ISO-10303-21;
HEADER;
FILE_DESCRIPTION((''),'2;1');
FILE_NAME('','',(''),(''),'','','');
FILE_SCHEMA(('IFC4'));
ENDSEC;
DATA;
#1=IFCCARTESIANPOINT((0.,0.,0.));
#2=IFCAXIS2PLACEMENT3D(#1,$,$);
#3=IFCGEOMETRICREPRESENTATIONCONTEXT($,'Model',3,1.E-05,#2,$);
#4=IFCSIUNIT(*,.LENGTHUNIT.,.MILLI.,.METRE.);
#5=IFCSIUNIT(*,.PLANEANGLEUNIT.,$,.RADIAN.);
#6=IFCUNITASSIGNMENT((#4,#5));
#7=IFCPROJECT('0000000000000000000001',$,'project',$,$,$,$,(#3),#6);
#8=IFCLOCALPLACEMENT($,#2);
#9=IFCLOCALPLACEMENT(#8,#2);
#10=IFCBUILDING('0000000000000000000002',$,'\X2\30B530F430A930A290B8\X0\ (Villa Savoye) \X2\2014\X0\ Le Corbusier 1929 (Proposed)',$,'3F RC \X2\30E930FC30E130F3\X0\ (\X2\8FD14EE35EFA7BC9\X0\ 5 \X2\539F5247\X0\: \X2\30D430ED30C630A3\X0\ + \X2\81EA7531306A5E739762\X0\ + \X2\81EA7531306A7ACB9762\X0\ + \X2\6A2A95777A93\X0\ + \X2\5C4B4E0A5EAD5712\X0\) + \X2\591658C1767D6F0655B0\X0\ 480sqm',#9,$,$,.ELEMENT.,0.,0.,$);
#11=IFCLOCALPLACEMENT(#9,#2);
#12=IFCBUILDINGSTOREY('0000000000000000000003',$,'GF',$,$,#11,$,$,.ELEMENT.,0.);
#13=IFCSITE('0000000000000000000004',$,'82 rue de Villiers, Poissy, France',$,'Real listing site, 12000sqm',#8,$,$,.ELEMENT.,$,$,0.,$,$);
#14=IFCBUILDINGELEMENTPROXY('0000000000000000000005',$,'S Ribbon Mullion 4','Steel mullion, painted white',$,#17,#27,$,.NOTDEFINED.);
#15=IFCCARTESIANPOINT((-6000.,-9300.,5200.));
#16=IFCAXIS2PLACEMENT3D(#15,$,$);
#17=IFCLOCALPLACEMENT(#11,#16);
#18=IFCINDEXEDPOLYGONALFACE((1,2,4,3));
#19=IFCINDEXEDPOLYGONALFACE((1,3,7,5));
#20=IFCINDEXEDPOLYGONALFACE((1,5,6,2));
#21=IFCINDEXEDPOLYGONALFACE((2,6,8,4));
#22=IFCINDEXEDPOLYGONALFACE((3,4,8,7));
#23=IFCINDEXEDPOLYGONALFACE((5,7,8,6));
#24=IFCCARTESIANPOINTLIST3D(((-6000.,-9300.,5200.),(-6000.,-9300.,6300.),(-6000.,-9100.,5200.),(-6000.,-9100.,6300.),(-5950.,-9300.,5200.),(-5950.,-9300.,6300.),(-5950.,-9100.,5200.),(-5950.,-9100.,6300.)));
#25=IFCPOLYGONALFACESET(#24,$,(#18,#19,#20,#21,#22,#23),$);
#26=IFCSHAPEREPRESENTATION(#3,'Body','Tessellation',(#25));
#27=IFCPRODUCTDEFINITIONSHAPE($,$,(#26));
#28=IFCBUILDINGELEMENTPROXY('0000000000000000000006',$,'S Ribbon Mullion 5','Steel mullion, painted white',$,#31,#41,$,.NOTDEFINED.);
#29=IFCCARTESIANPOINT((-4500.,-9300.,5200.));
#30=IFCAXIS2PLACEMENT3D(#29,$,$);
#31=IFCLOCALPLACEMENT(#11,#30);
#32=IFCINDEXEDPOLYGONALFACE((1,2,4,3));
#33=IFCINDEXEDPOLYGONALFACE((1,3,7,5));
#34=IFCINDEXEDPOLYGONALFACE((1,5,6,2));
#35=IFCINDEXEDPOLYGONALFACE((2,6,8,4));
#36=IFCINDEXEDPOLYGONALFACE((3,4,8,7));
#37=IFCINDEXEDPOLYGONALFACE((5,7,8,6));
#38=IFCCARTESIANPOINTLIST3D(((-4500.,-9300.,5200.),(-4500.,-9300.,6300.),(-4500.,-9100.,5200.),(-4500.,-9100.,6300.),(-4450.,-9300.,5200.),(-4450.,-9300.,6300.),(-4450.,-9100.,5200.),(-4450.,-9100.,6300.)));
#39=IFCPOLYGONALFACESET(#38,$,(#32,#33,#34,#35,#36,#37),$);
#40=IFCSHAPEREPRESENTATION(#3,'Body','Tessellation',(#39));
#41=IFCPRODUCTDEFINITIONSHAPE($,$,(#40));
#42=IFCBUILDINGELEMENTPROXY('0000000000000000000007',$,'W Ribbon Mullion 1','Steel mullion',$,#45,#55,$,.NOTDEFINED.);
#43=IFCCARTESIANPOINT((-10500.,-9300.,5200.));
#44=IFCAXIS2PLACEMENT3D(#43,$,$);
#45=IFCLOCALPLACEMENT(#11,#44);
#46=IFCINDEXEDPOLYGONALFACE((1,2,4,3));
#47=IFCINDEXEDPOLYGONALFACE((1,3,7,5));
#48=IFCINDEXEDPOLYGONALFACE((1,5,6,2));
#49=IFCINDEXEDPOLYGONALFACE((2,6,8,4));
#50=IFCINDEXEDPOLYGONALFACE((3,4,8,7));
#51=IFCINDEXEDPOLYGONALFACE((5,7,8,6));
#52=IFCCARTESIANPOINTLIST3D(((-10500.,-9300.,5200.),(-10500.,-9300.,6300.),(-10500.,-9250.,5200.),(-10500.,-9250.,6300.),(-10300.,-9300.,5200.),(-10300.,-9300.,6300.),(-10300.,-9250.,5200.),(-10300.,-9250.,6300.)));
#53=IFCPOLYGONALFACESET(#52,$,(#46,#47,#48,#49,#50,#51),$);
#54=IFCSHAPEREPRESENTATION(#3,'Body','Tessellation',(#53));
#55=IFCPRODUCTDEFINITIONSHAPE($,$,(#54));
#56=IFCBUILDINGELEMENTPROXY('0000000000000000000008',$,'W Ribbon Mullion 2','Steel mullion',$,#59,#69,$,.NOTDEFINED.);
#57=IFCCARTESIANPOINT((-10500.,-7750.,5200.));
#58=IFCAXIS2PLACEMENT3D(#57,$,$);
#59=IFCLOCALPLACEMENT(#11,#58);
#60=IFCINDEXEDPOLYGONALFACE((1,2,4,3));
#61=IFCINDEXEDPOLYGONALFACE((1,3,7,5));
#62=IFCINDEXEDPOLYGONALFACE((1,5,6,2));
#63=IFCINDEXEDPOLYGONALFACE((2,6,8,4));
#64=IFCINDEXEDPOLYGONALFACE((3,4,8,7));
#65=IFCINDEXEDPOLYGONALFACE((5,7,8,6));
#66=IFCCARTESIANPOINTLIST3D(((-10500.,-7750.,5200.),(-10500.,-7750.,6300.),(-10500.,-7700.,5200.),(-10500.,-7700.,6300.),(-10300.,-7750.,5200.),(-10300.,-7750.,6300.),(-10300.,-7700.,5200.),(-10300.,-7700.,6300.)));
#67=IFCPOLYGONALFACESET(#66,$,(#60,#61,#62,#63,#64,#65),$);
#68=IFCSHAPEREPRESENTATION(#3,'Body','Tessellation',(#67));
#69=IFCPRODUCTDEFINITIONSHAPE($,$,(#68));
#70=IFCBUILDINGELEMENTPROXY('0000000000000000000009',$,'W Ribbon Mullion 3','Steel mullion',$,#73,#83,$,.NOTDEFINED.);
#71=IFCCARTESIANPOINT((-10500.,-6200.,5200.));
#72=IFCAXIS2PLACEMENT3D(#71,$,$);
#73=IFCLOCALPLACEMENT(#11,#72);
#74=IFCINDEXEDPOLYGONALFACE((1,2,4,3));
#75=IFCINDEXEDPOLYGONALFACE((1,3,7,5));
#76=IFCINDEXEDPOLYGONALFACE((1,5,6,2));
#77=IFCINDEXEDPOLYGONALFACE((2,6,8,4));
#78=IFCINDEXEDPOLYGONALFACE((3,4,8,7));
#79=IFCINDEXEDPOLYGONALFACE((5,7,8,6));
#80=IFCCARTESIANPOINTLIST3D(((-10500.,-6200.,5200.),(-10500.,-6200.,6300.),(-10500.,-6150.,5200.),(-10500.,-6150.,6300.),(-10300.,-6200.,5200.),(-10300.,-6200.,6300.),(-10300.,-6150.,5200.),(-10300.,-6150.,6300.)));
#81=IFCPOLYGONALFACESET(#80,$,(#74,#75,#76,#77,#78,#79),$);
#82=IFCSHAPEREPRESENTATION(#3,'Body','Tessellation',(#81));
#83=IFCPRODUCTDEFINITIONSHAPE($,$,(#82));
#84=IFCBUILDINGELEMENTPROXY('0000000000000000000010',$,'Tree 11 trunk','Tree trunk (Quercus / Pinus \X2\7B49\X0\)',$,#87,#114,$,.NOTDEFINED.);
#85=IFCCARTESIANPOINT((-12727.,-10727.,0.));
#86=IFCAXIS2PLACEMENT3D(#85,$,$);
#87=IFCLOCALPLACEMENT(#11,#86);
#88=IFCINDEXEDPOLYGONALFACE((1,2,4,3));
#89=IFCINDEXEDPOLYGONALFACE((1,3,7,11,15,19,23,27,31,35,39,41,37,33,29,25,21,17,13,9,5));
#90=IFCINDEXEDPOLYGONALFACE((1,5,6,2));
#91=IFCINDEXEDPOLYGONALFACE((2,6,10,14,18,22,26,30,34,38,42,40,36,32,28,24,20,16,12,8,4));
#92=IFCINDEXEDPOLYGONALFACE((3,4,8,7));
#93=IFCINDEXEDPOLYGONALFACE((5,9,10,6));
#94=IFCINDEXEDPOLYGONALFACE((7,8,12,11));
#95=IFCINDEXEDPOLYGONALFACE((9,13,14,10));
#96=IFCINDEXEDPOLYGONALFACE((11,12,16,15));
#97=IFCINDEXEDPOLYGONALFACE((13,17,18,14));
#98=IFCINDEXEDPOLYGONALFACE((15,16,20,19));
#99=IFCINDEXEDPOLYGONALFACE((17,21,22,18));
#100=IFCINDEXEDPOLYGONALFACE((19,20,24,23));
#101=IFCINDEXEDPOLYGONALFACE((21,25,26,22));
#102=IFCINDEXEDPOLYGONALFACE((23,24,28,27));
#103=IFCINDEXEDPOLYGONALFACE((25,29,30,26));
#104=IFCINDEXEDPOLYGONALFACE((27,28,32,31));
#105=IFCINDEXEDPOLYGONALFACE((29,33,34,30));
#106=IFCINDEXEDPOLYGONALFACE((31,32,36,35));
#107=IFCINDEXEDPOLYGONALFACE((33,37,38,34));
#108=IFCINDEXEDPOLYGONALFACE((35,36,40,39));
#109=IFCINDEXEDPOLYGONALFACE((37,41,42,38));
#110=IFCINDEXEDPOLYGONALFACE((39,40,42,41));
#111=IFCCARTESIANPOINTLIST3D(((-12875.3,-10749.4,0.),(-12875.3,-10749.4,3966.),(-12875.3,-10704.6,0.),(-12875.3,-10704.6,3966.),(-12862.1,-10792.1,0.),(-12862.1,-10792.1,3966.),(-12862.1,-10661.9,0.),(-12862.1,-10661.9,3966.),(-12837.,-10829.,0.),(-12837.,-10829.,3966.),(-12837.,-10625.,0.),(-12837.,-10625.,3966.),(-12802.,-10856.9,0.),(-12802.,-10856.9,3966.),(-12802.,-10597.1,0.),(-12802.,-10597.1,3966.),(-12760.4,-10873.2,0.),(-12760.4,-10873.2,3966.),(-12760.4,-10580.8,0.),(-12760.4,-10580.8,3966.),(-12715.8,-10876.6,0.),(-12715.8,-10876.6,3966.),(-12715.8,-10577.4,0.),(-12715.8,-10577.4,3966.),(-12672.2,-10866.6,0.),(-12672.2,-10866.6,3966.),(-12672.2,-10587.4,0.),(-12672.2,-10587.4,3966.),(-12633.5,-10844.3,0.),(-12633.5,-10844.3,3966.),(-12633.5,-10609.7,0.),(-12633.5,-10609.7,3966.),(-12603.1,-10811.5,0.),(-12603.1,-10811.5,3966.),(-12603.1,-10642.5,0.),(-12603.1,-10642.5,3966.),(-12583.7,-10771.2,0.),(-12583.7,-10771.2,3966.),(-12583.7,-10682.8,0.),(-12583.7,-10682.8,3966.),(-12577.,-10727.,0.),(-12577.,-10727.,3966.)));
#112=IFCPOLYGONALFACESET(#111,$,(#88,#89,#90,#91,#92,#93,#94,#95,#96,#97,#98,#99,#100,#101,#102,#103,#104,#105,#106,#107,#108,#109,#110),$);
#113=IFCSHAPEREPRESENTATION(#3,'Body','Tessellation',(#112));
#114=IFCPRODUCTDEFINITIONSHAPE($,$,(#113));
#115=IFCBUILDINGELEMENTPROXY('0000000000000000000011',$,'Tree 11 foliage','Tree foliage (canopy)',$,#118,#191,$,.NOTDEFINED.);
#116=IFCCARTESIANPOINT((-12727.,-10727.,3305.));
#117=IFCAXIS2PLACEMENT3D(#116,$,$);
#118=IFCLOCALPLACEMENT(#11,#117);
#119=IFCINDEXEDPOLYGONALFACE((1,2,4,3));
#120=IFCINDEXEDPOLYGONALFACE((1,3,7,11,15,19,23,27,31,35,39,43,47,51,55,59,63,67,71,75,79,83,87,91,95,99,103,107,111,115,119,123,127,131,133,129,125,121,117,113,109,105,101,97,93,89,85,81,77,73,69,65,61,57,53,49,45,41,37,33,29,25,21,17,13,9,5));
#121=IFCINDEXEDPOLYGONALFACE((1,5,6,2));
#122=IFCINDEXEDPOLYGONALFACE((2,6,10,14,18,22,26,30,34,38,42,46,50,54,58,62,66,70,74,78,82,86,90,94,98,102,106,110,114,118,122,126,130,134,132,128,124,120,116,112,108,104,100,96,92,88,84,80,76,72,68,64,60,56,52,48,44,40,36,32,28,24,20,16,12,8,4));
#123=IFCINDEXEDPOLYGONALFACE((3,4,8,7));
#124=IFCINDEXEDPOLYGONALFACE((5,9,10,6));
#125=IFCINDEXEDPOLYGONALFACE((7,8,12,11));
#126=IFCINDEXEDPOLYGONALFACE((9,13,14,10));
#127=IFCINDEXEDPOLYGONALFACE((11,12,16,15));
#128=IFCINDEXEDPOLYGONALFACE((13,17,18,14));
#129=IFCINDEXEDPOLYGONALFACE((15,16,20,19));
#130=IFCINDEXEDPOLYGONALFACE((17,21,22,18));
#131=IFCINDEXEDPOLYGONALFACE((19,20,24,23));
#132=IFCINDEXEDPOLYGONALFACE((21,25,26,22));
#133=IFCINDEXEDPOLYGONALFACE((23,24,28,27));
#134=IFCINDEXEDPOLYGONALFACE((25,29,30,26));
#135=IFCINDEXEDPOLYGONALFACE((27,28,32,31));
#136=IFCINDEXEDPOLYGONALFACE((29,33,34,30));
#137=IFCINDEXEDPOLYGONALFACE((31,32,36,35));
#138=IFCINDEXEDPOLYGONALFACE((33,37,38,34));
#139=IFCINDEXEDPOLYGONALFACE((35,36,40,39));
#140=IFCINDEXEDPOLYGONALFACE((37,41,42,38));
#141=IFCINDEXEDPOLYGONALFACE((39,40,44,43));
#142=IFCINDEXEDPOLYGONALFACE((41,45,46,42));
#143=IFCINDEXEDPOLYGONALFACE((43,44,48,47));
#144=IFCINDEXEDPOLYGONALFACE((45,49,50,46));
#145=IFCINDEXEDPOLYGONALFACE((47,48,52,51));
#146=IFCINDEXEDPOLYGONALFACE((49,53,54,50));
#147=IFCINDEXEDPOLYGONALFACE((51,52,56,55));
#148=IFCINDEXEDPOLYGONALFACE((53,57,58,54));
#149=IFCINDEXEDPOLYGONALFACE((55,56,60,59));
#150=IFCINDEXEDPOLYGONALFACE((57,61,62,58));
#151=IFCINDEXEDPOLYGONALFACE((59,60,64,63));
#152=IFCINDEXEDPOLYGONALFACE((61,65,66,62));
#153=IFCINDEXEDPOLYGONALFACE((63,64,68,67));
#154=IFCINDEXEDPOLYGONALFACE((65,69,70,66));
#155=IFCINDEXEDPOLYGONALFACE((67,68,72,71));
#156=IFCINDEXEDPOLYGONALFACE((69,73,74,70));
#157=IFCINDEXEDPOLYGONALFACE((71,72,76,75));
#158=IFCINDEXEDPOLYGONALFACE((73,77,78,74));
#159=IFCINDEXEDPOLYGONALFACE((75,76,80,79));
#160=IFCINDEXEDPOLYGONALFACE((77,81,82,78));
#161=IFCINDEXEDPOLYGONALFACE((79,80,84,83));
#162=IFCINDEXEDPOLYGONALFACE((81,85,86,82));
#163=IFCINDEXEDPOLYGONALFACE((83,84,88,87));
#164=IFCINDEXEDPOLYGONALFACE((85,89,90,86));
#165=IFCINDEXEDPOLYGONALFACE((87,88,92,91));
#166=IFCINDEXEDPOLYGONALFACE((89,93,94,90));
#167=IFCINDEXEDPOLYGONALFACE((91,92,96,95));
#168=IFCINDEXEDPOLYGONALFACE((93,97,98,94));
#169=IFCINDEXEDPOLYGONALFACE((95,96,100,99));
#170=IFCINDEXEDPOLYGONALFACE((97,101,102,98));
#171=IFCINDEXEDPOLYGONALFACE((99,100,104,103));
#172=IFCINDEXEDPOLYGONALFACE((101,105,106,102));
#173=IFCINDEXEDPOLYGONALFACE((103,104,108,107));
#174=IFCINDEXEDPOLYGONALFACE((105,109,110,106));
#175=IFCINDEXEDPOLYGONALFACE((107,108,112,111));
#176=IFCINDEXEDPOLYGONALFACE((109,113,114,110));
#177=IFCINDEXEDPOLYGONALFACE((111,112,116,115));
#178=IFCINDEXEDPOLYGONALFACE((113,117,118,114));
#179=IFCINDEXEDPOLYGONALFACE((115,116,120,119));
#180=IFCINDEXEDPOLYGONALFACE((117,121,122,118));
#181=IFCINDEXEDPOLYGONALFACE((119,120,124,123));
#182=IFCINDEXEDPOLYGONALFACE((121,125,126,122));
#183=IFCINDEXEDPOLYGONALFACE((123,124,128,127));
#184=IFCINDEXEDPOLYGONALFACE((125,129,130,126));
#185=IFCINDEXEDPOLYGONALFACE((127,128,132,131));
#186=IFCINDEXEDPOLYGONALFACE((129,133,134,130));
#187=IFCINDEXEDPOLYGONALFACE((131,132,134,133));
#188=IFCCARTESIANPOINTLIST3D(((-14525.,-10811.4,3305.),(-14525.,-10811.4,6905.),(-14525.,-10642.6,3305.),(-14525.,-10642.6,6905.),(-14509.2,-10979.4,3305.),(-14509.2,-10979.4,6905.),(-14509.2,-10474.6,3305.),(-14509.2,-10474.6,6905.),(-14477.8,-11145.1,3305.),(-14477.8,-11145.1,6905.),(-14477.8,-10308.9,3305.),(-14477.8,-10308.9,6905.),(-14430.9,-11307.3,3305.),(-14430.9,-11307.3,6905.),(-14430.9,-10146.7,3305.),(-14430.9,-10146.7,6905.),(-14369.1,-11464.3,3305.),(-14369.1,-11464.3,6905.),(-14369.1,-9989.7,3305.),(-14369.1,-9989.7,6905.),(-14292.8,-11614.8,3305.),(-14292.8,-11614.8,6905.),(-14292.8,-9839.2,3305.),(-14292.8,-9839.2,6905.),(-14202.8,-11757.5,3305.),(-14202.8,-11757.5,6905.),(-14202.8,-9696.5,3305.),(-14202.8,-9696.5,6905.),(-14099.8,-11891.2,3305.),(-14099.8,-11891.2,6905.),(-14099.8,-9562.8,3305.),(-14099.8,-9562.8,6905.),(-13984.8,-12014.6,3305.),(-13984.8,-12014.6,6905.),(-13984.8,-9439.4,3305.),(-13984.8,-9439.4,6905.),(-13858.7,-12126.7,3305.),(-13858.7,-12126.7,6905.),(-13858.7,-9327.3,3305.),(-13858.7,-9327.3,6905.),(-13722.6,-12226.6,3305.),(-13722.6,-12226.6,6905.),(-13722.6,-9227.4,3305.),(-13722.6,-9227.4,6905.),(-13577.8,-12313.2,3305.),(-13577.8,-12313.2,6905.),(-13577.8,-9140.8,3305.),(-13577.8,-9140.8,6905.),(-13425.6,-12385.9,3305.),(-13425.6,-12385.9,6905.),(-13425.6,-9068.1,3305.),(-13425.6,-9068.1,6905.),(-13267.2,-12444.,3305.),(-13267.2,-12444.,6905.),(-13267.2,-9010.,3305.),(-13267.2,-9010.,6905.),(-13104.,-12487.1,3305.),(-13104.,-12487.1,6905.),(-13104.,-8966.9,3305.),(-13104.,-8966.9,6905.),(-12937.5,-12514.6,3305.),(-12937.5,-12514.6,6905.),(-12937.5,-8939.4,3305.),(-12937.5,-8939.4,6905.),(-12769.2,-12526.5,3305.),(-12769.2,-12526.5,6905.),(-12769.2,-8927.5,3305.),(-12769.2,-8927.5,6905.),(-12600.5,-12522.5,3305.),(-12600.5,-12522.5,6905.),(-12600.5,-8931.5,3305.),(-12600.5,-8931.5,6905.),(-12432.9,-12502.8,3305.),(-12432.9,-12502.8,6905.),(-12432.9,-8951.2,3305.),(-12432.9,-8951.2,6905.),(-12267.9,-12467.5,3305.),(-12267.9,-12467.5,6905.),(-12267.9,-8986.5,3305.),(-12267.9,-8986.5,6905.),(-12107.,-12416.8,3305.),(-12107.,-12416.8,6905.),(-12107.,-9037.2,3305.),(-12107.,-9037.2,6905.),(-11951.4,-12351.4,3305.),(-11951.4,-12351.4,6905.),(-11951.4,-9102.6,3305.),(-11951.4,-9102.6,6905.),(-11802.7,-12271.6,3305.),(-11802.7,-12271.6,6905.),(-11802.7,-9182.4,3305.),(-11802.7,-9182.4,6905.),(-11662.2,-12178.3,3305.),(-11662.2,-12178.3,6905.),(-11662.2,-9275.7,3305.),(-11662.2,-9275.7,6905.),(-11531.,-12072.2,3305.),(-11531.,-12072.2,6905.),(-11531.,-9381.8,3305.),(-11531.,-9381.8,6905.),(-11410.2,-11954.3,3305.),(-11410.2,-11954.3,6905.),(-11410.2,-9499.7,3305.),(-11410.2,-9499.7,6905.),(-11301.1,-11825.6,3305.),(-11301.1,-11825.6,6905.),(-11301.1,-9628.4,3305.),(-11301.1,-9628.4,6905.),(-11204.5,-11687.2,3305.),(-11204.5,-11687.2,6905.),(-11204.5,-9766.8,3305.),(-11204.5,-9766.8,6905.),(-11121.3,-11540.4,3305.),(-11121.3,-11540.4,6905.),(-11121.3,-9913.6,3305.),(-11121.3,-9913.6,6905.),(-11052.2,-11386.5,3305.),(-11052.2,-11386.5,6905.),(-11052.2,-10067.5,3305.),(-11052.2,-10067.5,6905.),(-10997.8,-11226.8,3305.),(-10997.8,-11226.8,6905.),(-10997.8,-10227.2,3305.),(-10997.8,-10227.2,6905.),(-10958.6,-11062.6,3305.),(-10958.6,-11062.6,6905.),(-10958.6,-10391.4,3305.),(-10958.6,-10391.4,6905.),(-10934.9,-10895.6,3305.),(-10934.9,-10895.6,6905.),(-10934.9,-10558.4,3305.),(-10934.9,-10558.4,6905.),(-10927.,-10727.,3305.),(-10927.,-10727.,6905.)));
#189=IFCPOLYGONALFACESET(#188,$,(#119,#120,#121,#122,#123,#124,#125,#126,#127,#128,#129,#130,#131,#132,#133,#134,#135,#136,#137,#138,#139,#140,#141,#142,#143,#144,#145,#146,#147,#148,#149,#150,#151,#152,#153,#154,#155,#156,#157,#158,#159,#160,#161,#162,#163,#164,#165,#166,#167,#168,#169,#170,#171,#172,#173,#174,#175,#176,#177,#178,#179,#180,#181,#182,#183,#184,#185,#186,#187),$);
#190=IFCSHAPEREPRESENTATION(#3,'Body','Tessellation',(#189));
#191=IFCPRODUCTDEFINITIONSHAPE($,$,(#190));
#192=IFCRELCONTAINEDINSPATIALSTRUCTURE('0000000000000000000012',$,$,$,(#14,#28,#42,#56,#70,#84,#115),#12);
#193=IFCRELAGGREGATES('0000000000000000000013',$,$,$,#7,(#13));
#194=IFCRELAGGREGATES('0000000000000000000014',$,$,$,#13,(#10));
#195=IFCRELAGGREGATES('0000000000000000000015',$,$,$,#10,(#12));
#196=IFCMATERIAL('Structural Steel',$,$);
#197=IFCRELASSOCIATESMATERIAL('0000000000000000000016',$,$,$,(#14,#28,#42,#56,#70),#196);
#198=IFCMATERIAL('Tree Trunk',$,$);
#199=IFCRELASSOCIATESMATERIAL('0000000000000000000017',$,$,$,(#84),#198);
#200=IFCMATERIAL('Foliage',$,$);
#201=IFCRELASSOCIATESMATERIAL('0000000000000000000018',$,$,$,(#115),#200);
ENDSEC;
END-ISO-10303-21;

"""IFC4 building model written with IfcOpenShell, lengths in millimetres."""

from ifc_helpers import new_model, si_unit, frame, frame_2d, origin, origin_2d, place, context, project, spatial, rectangle, circle, extrude, material, element, save


model = new_model("IFC4")

# Units and contexts
model_context = context("Model", 3, precision=1e-05, world=origin())
ifc_project = project(units=[si_unit("LENGTHUNIT", "METRE", prefix="MILLI"), si_unit("PLANEANGLEUNIT", "RADIAN")], contexts=[model_context])

# Site, building, storey
site_placement = place(None, origin())
site = spatial("IfcSite", under=ifc_project, at=site_placement, Name="82 rue de Villiers, Poissy, France", ObjectType="Real listing site, 12000sqm", CompositionType="ELEMENT", RefElevation=0.0)
building_placement = place(site_placement, origin())
building = spatial("IfcBuilding", under=site, at=building_placement, Name="サヴォア邸 (Villa Savoye) — Le Corbusier 1929 (Proposed)", ObjectType="3F RC ラーメン (近代建築 5 原則: ピロティ + 自由な平面 + 自由な立面 + 横長窓 + 屋上庭園) + 外壁白漆喰 480sqm", CompositionType="ELEMENT", ElevationOfRefHeight=0.0, ElevationOfTerrain=0.0)
storey_placement = place(building_placement, origin())
storey = spatial("IfcBuildingStorey", under=building, at=storey_placement, Name="GF", CompositionType="ELEMENT", Elevation=0.0)

# Building element proxies
ifc_material_1 = material(Name="Structural Steel")
proxy_1_placement = place(storey_placement, frame((-6000.0, -9300.0, 5200.0)))
element("IfcBuildingElementProxy", 1, at=proxy_1_placement, inside=storey, material=ifc_material_1, Name="S Ribbon Mullion 4", Description="Steel mullion, painted white", PredefinedType="NOTDEFINED", context=model_context, shape_type="SweptSolid", body=[
    extrude(rectangle(XDim=50.0, YDim=200.0, at=frame_2d((25.0, 100.0))), frame((-6000.0, -9300.0, 5200.0)), (0.0, 0.0, 1.0), 1100.0),
])
proxy_2_placement = place(storey_placement, frame((-4500.0, -9300.0, 5200.0)))
element("IfcBuildingElementProxy", 2, at=proxy_2_placement, inside=storey, material=ifc_material_1, Name="S Ribbon Mullion 5", Description="Steel mullion, painted white", PredefinedType="NOTDEFINED", context=model_context, shape_type="SweptSolid", body=[
    extrude(rectangle(XDim=50.0, YDim=200.0, at=frame_2d((25.0, 100.0))), frame((-4500.0, -9300.0, 5200.0)), (0.0, 0.0, 1.0), 1100.0),
])
proxy_3_placement = place(storey_placement, frame((-10500.0, -9300.0, 5200.0)))
element("IfcBuildingElementProxy", 3, at=proxy_3_placement, inside=storey, material=ifc_material_1, Name="W Ribbon Mullion 1", Description="Steel mullion", PredefinedType="NOTDEFINED", context=model_context, shape_type="SweptSolid", body=[
    extrude(rectangle(XDim=200.0, YDim=50.0, at=frame_2d((100.0, 25.0))), frame((-10500.0, -9300.0, 5200.0)), (0.0, 0.0, 1.0), 1100.0),
])
proxy_4_placement = place(storey_placement, frame((-10500.0, -7750.0, 5200.0)))
element("IfcBuildingElementProxy", 4, at=proxy_4_placement, inside=storey, material=ifc_material_1, Name="W Ribbon Mullion 2", Description="Steel mullion", PredefinedType="NOTDEFINED", context=model_context, shape_type="SweptSolid", body=[
    extrude(rectangle(XDim=200.0, YDim=50.0, at=frame_2d((100.0, 25.0))), frame((-10500.0, -7750.0, 5200.0)), (0.0, 0.0, 1.0), 1100.0),
])
proxy_5_placement = place(storey_placement, frame((-10500.0, -6200.0, 5200.0)))
element("IfcBuildingElementProxy", 5, at=proxy_5_placement, inside=storey, material=ifc_material_1, Name="W Ribbon Mullion 3", Description="Steel mullion", PredefinedType="NOTDEFINED", context=model_context, shape_type="SweptSolid", body=[
    extrude(rectangle(XDim=200.0, YDim=50.0, at=frame_2d((100.0, 25.0))), frame((-10500.0, -6200.0, 5200.0)), (0.0, 0.0, 1.0), 1100.0),
])
ifc_material_2 = material(Name="Tree Trunk")
proxy_6_placement = place(storey_placement, frame((-12727.0, -10727.0, 0.0)))
element("IfcBuildingElementProxy", 6, at=proxy_6_placement, inside=storey, material=ifc_material_2, Name="Tree 11 trunk", Description="Tree trunk (Quercus / Pinus 等)", PredefinedType="NOTDEFINED", context=model_context, shape_type="SweptSolid", body=[
    extrude(circle(Radius=150.0, at=origin_2d()), frame((-12727.0, -10727.0, 0.0)), (0.0, 0.0, 1.0), 3966.0),
])
ifc_material_3 = material(Name="Foliage")
proxy_7_placement = place(storey_placement, frame((-12727.0, -10727.0, 3305.0)))
element("IfcBuildingElementProxy", 7, at=proxy_7_placement, inside=storey, material=ifc_material_3, Name="Tree 11 foliage", Description="Tree foliage (canopy)", PredefinedType="NOTDEFINED", context=model_context, shape_type="SweptSolid", body=[
    extrude(circle(Radius=1800.0, at=origin_2d()), frame((-12727.0, -10727.0, 3305.0)), (0.0, 0.0, 1.0), 3600.0),
])

save(model, "model.ifc")
